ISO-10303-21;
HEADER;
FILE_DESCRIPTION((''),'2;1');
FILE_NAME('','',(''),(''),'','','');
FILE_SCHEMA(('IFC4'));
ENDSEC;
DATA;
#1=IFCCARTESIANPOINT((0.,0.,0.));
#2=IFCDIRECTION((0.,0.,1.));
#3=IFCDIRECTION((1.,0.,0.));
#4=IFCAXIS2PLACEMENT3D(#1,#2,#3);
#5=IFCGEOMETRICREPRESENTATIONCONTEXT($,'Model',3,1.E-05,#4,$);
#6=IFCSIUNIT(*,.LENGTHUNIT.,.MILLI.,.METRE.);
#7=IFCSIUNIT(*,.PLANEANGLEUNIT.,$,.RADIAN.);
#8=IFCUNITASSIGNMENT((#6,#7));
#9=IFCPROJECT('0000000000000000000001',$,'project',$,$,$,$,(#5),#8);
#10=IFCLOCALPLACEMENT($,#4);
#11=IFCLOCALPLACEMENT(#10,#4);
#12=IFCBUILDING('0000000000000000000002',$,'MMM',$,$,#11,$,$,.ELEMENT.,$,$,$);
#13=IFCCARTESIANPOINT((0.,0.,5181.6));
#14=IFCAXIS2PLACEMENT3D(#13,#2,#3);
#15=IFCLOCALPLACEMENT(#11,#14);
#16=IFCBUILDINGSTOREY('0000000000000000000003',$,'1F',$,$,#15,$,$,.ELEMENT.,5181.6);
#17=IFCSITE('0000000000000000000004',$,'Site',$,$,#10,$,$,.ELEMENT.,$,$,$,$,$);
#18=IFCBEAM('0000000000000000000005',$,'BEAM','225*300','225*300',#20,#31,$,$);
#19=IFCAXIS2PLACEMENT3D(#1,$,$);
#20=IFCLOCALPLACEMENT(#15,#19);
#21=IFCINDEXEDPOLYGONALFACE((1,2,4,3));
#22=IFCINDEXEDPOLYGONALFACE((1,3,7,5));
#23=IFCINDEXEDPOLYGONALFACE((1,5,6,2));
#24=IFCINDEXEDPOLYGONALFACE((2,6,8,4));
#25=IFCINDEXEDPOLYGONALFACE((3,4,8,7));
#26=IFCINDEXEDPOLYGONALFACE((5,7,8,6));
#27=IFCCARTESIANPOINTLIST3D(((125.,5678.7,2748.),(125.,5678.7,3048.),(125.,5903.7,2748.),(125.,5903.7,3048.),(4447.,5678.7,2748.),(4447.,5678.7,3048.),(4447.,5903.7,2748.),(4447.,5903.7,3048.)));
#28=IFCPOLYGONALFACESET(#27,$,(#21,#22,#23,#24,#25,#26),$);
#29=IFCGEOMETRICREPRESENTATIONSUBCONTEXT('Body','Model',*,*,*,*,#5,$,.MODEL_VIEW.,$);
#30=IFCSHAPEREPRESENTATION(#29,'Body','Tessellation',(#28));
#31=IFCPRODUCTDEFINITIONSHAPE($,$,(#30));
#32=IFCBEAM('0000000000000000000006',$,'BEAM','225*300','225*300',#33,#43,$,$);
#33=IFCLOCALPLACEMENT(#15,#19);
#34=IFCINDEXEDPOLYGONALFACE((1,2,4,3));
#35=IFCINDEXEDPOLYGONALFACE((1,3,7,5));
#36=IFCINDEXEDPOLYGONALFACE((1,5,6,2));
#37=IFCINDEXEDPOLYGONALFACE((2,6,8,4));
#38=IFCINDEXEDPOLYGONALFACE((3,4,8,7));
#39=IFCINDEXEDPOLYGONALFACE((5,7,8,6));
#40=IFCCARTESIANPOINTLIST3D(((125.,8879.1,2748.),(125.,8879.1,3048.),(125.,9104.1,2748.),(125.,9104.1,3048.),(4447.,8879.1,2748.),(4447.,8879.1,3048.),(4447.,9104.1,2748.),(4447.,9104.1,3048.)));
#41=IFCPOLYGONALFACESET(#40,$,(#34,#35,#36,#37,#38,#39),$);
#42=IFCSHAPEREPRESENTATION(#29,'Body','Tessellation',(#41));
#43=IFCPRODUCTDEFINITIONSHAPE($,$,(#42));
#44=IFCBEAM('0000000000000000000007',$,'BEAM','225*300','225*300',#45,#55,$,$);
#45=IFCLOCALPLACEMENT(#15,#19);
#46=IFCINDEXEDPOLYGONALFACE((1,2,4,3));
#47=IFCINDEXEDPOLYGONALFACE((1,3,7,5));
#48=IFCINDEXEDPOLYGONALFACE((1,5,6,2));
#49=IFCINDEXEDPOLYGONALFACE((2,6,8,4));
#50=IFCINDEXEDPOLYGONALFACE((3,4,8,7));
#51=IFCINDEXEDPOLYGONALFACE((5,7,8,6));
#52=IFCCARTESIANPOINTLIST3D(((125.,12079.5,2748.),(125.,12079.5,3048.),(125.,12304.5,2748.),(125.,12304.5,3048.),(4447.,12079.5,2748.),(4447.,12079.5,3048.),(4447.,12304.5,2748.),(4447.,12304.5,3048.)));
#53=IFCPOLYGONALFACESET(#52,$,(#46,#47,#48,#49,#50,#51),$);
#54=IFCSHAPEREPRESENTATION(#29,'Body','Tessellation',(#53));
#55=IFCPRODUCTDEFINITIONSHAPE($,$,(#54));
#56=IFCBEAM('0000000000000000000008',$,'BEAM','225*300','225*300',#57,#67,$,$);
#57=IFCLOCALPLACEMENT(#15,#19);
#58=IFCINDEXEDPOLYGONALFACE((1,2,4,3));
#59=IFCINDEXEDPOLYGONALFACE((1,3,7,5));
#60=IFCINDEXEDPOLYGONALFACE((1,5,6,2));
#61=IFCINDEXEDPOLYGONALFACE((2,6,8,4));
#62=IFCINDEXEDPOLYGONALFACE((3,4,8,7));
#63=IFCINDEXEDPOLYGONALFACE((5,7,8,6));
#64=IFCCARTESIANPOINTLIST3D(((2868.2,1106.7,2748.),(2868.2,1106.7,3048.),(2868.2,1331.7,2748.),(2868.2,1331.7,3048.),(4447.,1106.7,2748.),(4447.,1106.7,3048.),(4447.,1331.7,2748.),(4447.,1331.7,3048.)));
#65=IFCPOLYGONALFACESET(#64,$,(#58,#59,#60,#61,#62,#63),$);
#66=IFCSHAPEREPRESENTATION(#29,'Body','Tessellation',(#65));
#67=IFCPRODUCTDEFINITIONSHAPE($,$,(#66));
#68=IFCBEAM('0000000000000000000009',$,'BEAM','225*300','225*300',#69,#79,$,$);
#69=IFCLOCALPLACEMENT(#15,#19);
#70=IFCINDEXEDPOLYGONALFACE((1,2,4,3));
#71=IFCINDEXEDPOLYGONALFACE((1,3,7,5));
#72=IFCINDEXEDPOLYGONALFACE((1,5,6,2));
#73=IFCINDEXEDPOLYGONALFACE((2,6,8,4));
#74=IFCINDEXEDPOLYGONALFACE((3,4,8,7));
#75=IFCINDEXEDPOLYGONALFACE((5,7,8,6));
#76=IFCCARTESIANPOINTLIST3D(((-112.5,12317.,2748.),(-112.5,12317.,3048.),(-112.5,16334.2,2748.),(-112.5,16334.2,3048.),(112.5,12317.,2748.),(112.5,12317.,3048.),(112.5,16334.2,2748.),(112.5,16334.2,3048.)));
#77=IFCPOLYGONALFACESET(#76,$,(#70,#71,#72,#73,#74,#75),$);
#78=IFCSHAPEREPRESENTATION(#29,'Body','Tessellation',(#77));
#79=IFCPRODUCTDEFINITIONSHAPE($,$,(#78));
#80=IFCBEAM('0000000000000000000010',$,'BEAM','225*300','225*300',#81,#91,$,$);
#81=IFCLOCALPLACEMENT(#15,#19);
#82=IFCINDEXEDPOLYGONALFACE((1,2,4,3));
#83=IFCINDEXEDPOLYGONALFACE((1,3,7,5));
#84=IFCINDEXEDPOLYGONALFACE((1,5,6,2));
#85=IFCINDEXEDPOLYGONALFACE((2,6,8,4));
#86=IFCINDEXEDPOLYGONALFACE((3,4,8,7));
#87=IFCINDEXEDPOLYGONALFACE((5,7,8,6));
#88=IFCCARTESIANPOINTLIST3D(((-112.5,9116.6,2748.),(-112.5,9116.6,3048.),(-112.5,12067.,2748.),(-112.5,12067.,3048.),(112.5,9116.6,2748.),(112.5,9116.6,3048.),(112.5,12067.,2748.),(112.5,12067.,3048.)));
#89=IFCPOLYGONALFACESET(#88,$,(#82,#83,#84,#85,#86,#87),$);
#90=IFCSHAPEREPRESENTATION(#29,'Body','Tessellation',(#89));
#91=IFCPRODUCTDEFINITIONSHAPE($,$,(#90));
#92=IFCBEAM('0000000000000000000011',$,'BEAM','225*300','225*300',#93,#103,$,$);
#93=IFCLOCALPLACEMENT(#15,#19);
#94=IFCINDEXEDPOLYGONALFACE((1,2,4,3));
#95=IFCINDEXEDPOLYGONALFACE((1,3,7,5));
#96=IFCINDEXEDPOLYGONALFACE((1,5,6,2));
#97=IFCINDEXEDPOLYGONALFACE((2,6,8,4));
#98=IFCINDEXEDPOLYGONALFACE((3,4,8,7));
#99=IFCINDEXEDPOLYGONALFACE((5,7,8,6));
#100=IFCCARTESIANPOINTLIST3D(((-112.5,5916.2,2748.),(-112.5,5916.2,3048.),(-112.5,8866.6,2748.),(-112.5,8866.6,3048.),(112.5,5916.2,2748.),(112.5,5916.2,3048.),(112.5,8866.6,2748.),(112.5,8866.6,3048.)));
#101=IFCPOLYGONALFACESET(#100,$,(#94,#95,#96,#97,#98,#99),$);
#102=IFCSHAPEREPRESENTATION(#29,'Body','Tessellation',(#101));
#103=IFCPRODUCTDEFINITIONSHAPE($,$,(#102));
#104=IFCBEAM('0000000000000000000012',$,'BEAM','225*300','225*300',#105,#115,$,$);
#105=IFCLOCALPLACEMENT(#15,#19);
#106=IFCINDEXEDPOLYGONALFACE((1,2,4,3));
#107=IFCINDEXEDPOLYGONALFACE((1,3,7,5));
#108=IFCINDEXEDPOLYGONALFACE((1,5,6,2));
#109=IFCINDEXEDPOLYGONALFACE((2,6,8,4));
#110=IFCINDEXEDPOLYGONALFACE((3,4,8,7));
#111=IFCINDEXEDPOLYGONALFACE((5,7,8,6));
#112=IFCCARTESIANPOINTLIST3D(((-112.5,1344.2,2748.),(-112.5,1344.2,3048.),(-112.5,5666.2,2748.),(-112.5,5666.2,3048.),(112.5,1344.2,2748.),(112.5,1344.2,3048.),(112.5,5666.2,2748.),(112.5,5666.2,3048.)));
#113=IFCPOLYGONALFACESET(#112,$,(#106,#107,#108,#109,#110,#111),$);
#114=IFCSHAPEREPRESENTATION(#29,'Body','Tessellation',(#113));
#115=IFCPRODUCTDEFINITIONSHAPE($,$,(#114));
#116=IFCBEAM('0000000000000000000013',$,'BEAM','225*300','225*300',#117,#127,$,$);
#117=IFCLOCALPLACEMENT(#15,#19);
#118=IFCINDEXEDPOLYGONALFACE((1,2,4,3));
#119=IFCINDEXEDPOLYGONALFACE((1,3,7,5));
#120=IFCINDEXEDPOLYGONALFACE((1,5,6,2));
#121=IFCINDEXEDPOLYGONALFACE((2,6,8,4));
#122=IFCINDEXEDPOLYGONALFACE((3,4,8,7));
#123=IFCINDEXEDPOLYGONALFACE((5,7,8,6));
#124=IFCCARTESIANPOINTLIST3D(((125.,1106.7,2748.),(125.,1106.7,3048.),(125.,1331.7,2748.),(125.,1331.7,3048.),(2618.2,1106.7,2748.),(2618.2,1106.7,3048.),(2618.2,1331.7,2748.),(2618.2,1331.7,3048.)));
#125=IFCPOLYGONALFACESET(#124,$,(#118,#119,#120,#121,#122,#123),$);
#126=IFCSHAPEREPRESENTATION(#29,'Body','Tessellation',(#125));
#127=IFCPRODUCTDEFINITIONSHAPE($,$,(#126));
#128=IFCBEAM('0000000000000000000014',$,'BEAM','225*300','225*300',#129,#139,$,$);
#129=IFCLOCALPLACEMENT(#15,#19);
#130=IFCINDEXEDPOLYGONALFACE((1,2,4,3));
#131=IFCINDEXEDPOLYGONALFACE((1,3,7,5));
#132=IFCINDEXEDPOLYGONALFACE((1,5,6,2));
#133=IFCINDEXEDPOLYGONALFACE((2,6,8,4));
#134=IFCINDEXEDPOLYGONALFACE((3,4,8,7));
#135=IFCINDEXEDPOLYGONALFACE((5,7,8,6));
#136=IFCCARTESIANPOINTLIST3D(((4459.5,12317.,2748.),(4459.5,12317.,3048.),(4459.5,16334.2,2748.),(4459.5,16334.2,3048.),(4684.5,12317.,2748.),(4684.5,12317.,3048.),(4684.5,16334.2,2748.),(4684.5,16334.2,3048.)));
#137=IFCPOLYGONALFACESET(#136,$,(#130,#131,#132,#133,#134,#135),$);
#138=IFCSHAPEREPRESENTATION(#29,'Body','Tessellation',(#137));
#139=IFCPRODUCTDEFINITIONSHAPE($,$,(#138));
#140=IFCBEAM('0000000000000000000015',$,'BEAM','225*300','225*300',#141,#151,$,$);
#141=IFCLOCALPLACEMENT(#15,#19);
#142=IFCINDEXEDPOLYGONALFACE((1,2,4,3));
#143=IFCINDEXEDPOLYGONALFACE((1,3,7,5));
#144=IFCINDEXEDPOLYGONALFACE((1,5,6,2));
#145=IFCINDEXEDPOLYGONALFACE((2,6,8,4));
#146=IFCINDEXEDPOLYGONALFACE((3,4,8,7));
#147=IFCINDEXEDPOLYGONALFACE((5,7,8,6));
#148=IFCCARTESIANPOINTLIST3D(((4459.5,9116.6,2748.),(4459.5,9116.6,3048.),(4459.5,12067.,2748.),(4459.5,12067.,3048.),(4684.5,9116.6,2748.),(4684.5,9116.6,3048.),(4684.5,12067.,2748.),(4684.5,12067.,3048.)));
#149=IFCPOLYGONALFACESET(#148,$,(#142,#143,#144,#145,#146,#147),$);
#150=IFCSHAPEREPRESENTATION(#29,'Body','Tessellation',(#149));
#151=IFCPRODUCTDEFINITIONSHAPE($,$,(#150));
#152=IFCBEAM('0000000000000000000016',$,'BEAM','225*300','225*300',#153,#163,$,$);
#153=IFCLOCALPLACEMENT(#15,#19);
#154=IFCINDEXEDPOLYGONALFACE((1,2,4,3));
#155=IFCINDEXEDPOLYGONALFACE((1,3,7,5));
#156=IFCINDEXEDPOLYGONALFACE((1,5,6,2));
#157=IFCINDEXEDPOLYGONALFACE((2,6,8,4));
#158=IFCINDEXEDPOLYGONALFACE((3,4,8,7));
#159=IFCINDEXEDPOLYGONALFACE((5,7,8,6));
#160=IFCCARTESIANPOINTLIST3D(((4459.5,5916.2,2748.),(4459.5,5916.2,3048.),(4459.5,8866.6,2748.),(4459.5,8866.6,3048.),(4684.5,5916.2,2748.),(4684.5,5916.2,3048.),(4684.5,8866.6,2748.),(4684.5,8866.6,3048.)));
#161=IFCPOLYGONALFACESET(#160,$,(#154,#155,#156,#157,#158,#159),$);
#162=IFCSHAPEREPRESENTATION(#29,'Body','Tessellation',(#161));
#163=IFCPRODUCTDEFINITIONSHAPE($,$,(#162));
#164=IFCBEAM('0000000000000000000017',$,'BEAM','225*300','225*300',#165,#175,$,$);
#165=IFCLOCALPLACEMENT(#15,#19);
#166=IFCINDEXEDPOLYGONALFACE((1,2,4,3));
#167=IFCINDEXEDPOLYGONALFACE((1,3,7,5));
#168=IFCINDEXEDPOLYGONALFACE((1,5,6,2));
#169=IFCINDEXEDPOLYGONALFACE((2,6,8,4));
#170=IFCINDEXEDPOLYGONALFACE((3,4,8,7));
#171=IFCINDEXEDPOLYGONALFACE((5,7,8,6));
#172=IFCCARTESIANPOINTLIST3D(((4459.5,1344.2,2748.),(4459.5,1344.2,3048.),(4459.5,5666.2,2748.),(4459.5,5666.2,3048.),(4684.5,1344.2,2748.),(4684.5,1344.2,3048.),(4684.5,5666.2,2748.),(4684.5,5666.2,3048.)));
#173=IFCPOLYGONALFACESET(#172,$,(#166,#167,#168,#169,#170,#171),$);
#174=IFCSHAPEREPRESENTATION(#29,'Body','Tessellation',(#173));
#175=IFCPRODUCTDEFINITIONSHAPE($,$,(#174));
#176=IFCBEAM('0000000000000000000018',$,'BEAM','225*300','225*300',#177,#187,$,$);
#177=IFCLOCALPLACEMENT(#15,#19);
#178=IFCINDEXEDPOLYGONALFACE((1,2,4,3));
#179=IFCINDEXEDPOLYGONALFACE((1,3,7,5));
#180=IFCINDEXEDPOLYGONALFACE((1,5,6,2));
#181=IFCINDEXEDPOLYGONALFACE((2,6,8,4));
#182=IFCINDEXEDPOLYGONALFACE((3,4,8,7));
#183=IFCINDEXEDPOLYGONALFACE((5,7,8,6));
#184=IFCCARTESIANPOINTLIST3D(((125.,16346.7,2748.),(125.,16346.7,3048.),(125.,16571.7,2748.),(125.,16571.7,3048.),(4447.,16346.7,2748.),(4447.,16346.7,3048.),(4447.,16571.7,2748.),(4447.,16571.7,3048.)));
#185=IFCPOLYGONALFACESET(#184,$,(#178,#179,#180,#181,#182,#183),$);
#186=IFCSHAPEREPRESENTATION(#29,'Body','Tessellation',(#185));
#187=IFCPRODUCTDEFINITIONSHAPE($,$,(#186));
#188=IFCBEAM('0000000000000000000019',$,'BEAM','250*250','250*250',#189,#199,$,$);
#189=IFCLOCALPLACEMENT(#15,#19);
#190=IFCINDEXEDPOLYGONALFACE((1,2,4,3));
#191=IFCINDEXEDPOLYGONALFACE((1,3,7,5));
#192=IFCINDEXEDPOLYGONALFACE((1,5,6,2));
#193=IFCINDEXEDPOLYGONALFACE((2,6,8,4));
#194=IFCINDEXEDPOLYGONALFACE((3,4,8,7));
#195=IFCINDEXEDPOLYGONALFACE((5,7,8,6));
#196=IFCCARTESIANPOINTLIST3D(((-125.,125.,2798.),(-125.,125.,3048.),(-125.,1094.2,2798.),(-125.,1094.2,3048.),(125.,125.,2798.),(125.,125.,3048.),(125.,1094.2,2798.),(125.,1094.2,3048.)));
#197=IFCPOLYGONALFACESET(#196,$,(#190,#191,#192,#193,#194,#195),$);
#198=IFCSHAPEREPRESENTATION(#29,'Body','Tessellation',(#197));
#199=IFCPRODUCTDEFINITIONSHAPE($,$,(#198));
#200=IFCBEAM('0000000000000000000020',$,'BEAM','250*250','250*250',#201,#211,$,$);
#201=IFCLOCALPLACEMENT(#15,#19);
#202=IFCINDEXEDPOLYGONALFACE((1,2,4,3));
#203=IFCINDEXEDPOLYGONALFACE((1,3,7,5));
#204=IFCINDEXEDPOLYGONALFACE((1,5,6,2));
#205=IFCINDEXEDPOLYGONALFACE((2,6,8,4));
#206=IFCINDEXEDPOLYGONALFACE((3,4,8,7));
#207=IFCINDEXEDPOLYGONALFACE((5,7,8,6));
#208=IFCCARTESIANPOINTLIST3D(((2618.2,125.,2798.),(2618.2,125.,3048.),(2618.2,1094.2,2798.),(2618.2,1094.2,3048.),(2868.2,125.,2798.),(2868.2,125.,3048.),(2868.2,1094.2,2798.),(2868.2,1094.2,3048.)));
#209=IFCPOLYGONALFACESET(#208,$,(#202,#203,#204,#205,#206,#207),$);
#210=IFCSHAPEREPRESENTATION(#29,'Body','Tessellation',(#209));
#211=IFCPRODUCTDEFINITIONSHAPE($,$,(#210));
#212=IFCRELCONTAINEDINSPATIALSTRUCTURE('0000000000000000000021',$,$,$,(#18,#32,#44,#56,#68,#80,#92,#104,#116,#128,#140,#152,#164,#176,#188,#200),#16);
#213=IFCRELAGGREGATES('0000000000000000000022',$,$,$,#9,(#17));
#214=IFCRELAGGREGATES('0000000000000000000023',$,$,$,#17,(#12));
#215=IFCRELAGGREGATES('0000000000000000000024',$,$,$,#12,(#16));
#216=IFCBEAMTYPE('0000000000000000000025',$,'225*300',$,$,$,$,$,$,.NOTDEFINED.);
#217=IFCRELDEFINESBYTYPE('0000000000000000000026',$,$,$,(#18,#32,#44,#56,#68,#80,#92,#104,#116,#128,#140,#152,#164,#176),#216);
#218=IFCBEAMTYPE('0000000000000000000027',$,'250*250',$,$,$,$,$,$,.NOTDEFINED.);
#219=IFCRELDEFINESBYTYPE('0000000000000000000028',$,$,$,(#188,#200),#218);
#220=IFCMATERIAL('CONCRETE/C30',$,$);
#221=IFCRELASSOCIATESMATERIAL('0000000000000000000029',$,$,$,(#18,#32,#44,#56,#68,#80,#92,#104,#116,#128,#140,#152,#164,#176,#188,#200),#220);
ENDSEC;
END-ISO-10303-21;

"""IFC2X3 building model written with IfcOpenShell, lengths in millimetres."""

from ifc_helpers import new_model, si_unit, frame, origin_with_axes, origin_2d_with_axis, place, context, subcontext, project, spatial, rectangle, extrude, material, type_object, element, save


model = new_model("IFC2X3")

# Units and contexts
model_context = context("Model", 3, precision=1e-05, world=origin_with_axes())
body_context = subcontext(model_context, "Body", "Model", "MODEL_VIEW")
ifc_project = project(units=[si_unit("LENGTHUNIT", "METRE", prefix="MILLI"), si_unit("PLANEANGLEUNIT", "RADIAN")], contexts=[model_context])

# Site, building, storey
site_placement = place(None, origin_with_axes())
site = spatial("IfcSite", under=ifc_project, at=site_placement, Name="Site", CompositionType="ELEMENT")
building_placement = place(site_placement, origin_with_axes())
building = spatial("IfcBuilding", under=site, at=building_placement, Name="MMM", CompositionType="ELEMENT")
storey_placement = place(building_placement, frame((0.0, 0.0, 5181.6), z_axis=(0.0, 0.0, 1.0), x_axis=(1.0, 0.0, 0.0)))
storey = spatial("IfcBuildingStorey", under=building, at=storey_placement, Name="1F", CompositionType="ELEMENT", Elevation=5181.6)

# Beams
ifc_material = material(Name="CONCRETE/C30")
beam_type_1 = type_object("IfcBeamType", Name="225*300", PredefinedType="NOTDEFINED")
for number, where, z_axis, x_axis, name in (
    (1, (125.0, 5791.2, 2898.0), (0.0, 0.0, 1.0), (1.0, 0.0, 0.0), "BEAM"),
    (2, (125.0, 8991.6, 2898.0), (0.0, 0.0, 1.0), (1.0, 0.0, 0.0), "BEAM"),
    (3, (125.0, 12192.0, 2898.0), (0.0, 0.0, 1.0), (1.0, 0.0, 0.0), "BEAM"),
):
    element("IfcBeam", number, at=place(storey_placement, frame(where, z_axis=z_axis, x_axis=x_axis)), inside=storey, type_object=beam_type_1, material=ifc_material, Name=name, Description="225*300", ObjectType="225*300", context=body_context, shape_type="SweptSolid", body=[
        extrude(rectangle(XDim=225.0, YDim=300.0, at=origin_2d_with_axis()), frame((4322.0, 0.0, 0.0), z_axis=(-1.0, 0.0, 0.0), x_axis=(0.0, -1.0, 0.0)), (0.0, 0.0, 1.0), 4322.0),
    ])
beam_1_placement = place(storey_placement, frame((2868.2, 1219.2, 2898.0), z_axis=(0.0, 0.0, 1.0), x_axis=(1.0, 0.0, 0.0)))
element("IfcBeam", 4, at=beam_1_placement, inside=storey, type_object=beam_type_1, material=ifc_material, Name="BEAM", Description="225*300", ObjectType="225*300", context=body_context, shape_type="SweptSolid", body=[
    extrude(rectangle(XDim=225.0, YDim=300.0, at=origin_2d_with_axis()), frame((1578.8, 0.0, 0.0), z_axis=(-1.0, 0.0, 0.0), x_axis=(0.0, -1.0, 0.0)), (0.0, 0.0, 1.0), 1578.8),
])
beam_2_placement = place(storey_placement, frame((0.0, 12317.0, 2898.0), z_axis=(0.0, 0.0, 1.0), x_axis=(0.0, 1.0, 0.0)))
element("IfcBeam", 5, at=beam_2_placement, inside=storey, type_object=beam_type_1, material=ifc_material, Name="BEAM", Description="225*300", ObjectType="225*300", context=body_context, shape_type="SweptSolid", body=[
    extrude(rectangle(XDim=225.0, YDim=300.0, at=origin_2d_with_axis()), frame((4017.2, 0.0, 0.0), z_axis=(-1.0, 0.0, 0.0), x_axis=(0.0, -1.0, 0.0)), (0.0, 0.0, 1.0), 4017.2),
])
for number, where, z_axis, x_axis, name in (
    (6, (0.0, 9116.6, 2898.0), (0.0, 0.0, 1.0), (0.0, 1.0, 0.0), "BEAM"),
    (7, (0.0, 5916.2, 2898.0), (0.0, 0.0, 1.0), (0.0, 1.0, 0.0), "BEAM"),
):
    element("IfcBeam", number, at=place(storey_placement, frame(where, z_axis=z_axis, x_axis=x_axis)), inside=storey, type_object=beam_type_1, material=ifc_material, Name=name, Description="225*300", ObjectType="225*300", context=body_context, shape_type="SweptSolid", body=[
        extrude(rectangle(XDim=225.0, YDim=300.0, at=origin_2d_with_axis()), frame((2950.4, 0.0, 0.0), z_axis=(-1.0, 0.0, 0.0), x_axis=(0.0, -1.0, 0.0)), (0.0, 0.0, 1.0), 2950.4),
    ])
beam_3_placement = place(storey_placement, frame((0.0, 1344.2, 2898.0), z_axis=(0.0, 0.0, 1.0), x_axis=(0.0, 1.0, 0.0)))
element("IfcBeam", 8, at=beam_3_placement, inside=storey, type_object=beam_type_1, material=ifc_material, Name="BEAM", Description="225*300", ObjectType="225*300", context=body_context, shape_type="SweptSolid", body=[
    extrude(rectangle(XDim=225.0, YDim=300.0, at=origin_2d_with_axis()), frame((4322.0, 0.0, 0.0), z_axis=(-1.0, 0.0, 0.0), x_axis=(0.0, -1.0, 0.0)), (0.0, 0.0, 1.0), 4322.0),
])
beam_4_placement = place(storey_placement, frame((125.0, 1219.2, 2898.0), z_axis=(0.0, 0.0, 1.0), x_axis=(1.0, 0.0, 0.0)))
element("IfcBeam", 9, at=beam_4_placement, inside=storey, type_object=beam_type_1, material=ifc_material, Name="BEAM", Description="225*300", ObjectType="225*300", context=body_context, shape_type="SweptSolid", body=[
    extrude(rectangle(XDim=225.0, YDim=300.0, at=origin_2d_with_axis()), frame((2493.2, 0.0, 0.0), z_axis=(-1.0, 0.0, 0.0), x_axis=(0.0, -1.0, 0.0)), (0.0, 0.0, 1.0), 2493.2),
])
beam_5_placement = place(storey_placement, frame((4572.0, 12317.0, 2898.0), z_axis=(0.0, 0.0, 1.0), x_axis=(0.0, 1.0, 0.0)))
element("IfcBeam", 10, at=beam_5_placement, inside=storey, type_object=beam_type_1, material=ifc_material, Name="BEAM", Description="225*300", ObjectType="225*300", context=body_context, shape_type="SweptSolid", body=[
    extrude(rectangle(XDim=225.0, YDim=300.0, at=origin_2d_with_axis()), frame((4017.2, 0.0, 0.0), z_axis=(-1.0, 0.0, 0.0), x_axis=(0.0, -1.0, 0.0)), (0.0, 0.0, 1.0), 4017.2),
])
for number, where, z_axis, x_axis, name in (
    (11, (4572.0, 9116.6, 2898.0), (0.0, 0.0, 1.0), (0.0, 1.0, 0.0), "BEAM"),
    (12, (4572.0, 5916.2, 2898.0), (0.0, 0.0, 1.0), (0.0, 1.0, 0.0), "BEAM"),
):
    element("IfcBeam", number, at=place(storey_placement, frame(where, z_axis=z_axis, x_axis=x_axis)), inside=storey, type_object=beam_type_1, material=ifc_material, Name=name, Description="225*300", ObjectType="225*300", context=body_context, shape_type="SweptSolid", body=[
        extrude(rectangle(XDim=225.0, YDim=300.0, at=origin_2d_with_axis()), frame((2950.4, 0.0, 0.0), z_axis=(-1.0, 0.0, 0.0), x_axis=(0.0, -1.0, 0.0)), (0.0, 0.0, 1.0), 2950.4),
    ])
for number, where, z_axis, x_axis, name in (
    (13, (4572.0, 1344.2, 2898.0), (0.0, 0.0, 1.0), (0.0, 1.0, 0.0), "BEAM"),
    (14, (125.0, 16459.2, 2898.0), (0.0, 0.0, 1.0), (1.0, 0.0, 0.0), "BEAM"),
):
    element("IfcBeam", number, at=place(storey_placement, frame(where, z_axis=z_axis, x_axis=x_axis)), inside=storey, type_object=beam_type_1, material=ifc_material, Name=name, Description="225*300", ObjectType="225*300", context=body_context, shape_type="SweptSolid", body=[
        extrude(rectangle(XDim=225.0, YDim=300.0, at=origin_2d_with_axis()), frame((4322.0, 0.0, 0.0), z_axis=(-1.0, 0.0, 0.0), x_axis=(0.0, -1.0, 0.0)), (0.0, 0.0, 1.0), 4322.0),
    ])
beam_type_2 = type_object("IfcBeamType", Name="250*250", PredefinedType="NOTDEFINED")
for number, where, z_axis, x_axis, name in (
    (15, (0.0, 125.0, 2923.0), (0.0, 0.0, 1.0), (0.0, 1.0, 0.0), "BEAM"),
    (16, (2743.2, 125.0, 2923.0), (0.0, 0.0, 1.0), (0.0, 1.0, 0.0), "BEAM"),
):
    element("IfcBeam", number, at=place(storey_placement, frame(where, z_axis=z_axis, x_axis=x_axis)), inside=storey, type_object=beam_type_2, material=ifc_material, Name=name, Description="250*250", ObjectType="250*250", context=body_context, shape_type="SweptSolid", body=[
        extrude(rectangle(XDim=250.0, YDim=250.0, at=origin_2d_with_axis()), frame((969.2, 0.0, 0.0), z_axis=(-1.0, 0.0, 0.0), x_axis=(0.0, -1.0, 0.0)), (0.0, 0.0, 1.0), 969.2),
    ])

save(model, "model.ifc")
